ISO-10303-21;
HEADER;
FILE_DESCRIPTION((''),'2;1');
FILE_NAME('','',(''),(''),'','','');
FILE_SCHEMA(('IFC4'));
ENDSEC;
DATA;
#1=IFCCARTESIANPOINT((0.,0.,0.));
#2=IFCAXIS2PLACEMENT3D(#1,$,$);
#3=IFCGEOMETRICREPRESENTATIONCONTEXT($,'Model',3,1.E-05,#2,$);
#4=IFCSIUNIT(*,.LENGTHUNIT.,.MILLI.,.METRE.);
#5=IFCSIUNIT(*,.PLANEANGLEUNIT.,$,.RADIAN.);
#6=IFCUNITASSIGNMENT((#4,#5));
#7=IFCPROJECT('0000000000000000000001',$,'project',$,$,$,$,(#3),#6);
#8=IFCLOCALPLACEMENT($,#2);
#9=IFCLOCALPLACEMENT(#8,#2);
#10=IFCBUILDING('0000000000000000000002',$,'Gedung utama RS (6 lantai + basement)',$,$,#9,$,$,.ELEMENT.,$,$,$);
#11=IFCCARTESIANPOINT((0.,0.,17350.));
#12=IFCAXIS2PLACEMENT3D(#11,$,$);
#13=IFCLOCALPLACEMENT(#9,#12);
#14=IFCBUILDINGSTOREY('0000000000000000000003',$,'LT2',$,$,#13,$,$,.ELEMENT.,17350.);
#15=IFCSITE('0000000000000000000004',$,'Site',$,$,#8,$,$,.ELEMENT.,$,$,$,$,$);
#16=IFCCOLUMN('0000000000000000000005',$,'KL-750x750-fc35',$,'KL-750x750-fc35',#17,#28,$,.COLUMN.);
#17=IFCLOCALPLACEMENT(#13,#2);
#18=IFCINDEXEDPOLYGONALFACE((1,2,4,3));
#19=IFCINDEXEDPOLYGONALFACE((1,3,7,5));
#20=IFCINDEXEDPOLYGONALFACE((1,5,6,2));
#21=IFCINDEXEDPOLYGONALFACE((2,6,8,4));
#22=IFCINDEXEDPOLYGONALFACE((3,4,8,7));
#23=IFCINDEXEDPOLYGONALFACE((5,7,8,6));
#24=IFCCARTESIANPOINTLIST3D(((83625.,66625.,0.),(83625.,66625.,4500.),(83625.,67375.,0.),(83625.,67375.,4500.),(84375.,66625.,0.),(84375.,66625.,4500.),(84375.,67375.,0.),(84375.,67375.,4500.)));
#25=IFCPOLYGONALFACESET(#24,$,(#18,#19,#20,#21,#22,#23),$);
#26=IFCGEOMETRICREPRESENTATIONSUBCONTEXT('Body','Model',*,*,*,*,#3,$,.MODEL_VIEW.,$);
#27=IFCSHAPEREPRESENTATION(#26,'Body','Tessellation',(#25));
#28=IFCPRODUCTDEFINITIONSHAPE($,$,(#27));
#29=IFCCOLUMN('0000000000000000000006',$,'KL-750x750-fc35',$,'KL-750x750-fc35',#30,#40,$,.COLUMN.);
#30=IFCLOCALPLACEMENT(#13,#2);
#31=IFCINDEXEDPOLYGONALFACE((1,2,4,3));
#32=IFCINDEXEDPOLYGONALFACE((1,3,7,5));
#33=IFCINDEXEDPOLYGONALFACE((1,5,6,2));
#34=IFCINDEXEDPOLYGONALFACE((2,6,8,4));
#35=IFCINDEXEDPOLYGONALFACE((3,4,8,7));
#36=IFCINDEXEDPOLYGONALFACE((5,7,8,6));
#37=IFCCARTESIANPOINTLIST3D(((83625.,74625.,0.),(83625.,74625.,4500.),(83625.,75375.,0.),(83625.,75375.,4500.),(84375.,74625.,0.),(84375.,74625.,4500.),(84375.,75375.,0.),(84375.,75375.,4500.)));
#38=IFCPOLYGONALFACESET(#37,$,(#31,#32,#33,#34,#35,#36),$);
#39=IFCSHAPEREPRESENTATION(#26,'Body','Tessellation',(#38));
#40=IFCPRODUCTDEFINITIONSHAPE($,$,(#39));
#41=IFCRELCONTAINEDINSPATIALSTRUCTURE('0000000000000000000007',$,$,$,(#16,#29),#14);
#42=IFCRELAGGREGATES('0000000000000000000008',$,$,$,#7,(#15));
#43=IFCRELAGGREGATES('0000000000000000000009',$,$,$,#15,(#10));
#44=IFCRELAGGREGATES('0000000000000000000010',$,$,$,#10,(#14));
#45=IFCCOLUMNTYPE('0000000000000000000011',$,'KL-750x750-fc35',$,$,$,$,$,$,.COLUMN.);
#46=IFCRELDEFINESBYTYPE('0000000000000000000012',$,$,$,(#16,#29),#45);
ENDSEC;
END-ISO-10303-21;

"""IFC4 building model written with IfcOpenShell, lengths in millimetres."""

from ifc_helpers import new_model, si_unit, frame, origin, origin_2d, place, context, subcontext, project, spatial, rectangle, extrude, material_profile, profile_set, profile_usage, type_object, element, save


model = new_model("IFC4")

# Units and contexts
model_context = context("Model", 3, precision=1e-05, world=origin())
body_context = subcontext(model_context, "Body", "Model", "MODEL_VIEW")
ifc_project = project(units=[si_unit("LENGTHUNIT", "METRE", prefix="MILLI"), si_unit("PLANEANGLEUNIT", "RADIAN")], contexts=[model_context])

# Site, building, storey
site_placement = place(None, origin())
site = spatial("IfcSite", under=ifc_project, at=site_placement, Name="Site", CompositionType="ELEMENT")
building_placement = place(site_placement, origin())
building = spatial("IfcBuilding", under=site, at=building_placement, Name="Gedung utama RS (6 lantai + basement)", CompositionType="ELEMENT")
storey_placement = place(building_placement, frame((0.0, 0.0, 17350.0)))
storey = spatial("IfcBuildingStorey", under=building, at=storey_placement, Name="LT2", CompositionType="ELEMENT", Elevation=17350.0)

# Columns
ifc_material_profile = material_profile(None, rectangle(XDim=750.0, YDim=750.0, at=origin_2d()), Name="KL-750x750-fc35")
ifc_profile_set = profile_set([ifc_material_profile], Name="KL-750x750-fc35")
ifc_profile_usage = profile_usage(ifc_profile_set, cardinal=5)
column_type = type_object("IfcColumnType", Name="KL-750x750-fc35", PredefinedType="COLUMN", material=ifc_profile_set)
for number, where, z_axis, x_axis, name in (
    (1, (84000.0, 67000.0, 0.0), (0.0, 0.0, 1.0), (1.0, 0.0, 0.0), "KL-750x750-fc35"),
    (2, (84000.0, 75000.0, 0.0), (0.0, 0.0, 1.0), (1.0, 0.0, 0.0), "KL-750x750-fc35"),
):
    element("IfcColumn", number, at=place(storey_placement, frame(where, z_axis=z_axis, x_axis=x_axis)), inside=storey, type_object=column_type, material=ifc_profile_usage, Name=name, ObjectType="KL-750x750-fc35", PredefinedType="COLUMN", context=body_context, shape_type="SweptSolid", body=[
        extrude(rectangle(XDim=750.0, YDim=750.0, at=origin_2d()), origin(), (0.0, 0.0, 1.0), 4500.0),
    ])

save(model, "model.ifc")
